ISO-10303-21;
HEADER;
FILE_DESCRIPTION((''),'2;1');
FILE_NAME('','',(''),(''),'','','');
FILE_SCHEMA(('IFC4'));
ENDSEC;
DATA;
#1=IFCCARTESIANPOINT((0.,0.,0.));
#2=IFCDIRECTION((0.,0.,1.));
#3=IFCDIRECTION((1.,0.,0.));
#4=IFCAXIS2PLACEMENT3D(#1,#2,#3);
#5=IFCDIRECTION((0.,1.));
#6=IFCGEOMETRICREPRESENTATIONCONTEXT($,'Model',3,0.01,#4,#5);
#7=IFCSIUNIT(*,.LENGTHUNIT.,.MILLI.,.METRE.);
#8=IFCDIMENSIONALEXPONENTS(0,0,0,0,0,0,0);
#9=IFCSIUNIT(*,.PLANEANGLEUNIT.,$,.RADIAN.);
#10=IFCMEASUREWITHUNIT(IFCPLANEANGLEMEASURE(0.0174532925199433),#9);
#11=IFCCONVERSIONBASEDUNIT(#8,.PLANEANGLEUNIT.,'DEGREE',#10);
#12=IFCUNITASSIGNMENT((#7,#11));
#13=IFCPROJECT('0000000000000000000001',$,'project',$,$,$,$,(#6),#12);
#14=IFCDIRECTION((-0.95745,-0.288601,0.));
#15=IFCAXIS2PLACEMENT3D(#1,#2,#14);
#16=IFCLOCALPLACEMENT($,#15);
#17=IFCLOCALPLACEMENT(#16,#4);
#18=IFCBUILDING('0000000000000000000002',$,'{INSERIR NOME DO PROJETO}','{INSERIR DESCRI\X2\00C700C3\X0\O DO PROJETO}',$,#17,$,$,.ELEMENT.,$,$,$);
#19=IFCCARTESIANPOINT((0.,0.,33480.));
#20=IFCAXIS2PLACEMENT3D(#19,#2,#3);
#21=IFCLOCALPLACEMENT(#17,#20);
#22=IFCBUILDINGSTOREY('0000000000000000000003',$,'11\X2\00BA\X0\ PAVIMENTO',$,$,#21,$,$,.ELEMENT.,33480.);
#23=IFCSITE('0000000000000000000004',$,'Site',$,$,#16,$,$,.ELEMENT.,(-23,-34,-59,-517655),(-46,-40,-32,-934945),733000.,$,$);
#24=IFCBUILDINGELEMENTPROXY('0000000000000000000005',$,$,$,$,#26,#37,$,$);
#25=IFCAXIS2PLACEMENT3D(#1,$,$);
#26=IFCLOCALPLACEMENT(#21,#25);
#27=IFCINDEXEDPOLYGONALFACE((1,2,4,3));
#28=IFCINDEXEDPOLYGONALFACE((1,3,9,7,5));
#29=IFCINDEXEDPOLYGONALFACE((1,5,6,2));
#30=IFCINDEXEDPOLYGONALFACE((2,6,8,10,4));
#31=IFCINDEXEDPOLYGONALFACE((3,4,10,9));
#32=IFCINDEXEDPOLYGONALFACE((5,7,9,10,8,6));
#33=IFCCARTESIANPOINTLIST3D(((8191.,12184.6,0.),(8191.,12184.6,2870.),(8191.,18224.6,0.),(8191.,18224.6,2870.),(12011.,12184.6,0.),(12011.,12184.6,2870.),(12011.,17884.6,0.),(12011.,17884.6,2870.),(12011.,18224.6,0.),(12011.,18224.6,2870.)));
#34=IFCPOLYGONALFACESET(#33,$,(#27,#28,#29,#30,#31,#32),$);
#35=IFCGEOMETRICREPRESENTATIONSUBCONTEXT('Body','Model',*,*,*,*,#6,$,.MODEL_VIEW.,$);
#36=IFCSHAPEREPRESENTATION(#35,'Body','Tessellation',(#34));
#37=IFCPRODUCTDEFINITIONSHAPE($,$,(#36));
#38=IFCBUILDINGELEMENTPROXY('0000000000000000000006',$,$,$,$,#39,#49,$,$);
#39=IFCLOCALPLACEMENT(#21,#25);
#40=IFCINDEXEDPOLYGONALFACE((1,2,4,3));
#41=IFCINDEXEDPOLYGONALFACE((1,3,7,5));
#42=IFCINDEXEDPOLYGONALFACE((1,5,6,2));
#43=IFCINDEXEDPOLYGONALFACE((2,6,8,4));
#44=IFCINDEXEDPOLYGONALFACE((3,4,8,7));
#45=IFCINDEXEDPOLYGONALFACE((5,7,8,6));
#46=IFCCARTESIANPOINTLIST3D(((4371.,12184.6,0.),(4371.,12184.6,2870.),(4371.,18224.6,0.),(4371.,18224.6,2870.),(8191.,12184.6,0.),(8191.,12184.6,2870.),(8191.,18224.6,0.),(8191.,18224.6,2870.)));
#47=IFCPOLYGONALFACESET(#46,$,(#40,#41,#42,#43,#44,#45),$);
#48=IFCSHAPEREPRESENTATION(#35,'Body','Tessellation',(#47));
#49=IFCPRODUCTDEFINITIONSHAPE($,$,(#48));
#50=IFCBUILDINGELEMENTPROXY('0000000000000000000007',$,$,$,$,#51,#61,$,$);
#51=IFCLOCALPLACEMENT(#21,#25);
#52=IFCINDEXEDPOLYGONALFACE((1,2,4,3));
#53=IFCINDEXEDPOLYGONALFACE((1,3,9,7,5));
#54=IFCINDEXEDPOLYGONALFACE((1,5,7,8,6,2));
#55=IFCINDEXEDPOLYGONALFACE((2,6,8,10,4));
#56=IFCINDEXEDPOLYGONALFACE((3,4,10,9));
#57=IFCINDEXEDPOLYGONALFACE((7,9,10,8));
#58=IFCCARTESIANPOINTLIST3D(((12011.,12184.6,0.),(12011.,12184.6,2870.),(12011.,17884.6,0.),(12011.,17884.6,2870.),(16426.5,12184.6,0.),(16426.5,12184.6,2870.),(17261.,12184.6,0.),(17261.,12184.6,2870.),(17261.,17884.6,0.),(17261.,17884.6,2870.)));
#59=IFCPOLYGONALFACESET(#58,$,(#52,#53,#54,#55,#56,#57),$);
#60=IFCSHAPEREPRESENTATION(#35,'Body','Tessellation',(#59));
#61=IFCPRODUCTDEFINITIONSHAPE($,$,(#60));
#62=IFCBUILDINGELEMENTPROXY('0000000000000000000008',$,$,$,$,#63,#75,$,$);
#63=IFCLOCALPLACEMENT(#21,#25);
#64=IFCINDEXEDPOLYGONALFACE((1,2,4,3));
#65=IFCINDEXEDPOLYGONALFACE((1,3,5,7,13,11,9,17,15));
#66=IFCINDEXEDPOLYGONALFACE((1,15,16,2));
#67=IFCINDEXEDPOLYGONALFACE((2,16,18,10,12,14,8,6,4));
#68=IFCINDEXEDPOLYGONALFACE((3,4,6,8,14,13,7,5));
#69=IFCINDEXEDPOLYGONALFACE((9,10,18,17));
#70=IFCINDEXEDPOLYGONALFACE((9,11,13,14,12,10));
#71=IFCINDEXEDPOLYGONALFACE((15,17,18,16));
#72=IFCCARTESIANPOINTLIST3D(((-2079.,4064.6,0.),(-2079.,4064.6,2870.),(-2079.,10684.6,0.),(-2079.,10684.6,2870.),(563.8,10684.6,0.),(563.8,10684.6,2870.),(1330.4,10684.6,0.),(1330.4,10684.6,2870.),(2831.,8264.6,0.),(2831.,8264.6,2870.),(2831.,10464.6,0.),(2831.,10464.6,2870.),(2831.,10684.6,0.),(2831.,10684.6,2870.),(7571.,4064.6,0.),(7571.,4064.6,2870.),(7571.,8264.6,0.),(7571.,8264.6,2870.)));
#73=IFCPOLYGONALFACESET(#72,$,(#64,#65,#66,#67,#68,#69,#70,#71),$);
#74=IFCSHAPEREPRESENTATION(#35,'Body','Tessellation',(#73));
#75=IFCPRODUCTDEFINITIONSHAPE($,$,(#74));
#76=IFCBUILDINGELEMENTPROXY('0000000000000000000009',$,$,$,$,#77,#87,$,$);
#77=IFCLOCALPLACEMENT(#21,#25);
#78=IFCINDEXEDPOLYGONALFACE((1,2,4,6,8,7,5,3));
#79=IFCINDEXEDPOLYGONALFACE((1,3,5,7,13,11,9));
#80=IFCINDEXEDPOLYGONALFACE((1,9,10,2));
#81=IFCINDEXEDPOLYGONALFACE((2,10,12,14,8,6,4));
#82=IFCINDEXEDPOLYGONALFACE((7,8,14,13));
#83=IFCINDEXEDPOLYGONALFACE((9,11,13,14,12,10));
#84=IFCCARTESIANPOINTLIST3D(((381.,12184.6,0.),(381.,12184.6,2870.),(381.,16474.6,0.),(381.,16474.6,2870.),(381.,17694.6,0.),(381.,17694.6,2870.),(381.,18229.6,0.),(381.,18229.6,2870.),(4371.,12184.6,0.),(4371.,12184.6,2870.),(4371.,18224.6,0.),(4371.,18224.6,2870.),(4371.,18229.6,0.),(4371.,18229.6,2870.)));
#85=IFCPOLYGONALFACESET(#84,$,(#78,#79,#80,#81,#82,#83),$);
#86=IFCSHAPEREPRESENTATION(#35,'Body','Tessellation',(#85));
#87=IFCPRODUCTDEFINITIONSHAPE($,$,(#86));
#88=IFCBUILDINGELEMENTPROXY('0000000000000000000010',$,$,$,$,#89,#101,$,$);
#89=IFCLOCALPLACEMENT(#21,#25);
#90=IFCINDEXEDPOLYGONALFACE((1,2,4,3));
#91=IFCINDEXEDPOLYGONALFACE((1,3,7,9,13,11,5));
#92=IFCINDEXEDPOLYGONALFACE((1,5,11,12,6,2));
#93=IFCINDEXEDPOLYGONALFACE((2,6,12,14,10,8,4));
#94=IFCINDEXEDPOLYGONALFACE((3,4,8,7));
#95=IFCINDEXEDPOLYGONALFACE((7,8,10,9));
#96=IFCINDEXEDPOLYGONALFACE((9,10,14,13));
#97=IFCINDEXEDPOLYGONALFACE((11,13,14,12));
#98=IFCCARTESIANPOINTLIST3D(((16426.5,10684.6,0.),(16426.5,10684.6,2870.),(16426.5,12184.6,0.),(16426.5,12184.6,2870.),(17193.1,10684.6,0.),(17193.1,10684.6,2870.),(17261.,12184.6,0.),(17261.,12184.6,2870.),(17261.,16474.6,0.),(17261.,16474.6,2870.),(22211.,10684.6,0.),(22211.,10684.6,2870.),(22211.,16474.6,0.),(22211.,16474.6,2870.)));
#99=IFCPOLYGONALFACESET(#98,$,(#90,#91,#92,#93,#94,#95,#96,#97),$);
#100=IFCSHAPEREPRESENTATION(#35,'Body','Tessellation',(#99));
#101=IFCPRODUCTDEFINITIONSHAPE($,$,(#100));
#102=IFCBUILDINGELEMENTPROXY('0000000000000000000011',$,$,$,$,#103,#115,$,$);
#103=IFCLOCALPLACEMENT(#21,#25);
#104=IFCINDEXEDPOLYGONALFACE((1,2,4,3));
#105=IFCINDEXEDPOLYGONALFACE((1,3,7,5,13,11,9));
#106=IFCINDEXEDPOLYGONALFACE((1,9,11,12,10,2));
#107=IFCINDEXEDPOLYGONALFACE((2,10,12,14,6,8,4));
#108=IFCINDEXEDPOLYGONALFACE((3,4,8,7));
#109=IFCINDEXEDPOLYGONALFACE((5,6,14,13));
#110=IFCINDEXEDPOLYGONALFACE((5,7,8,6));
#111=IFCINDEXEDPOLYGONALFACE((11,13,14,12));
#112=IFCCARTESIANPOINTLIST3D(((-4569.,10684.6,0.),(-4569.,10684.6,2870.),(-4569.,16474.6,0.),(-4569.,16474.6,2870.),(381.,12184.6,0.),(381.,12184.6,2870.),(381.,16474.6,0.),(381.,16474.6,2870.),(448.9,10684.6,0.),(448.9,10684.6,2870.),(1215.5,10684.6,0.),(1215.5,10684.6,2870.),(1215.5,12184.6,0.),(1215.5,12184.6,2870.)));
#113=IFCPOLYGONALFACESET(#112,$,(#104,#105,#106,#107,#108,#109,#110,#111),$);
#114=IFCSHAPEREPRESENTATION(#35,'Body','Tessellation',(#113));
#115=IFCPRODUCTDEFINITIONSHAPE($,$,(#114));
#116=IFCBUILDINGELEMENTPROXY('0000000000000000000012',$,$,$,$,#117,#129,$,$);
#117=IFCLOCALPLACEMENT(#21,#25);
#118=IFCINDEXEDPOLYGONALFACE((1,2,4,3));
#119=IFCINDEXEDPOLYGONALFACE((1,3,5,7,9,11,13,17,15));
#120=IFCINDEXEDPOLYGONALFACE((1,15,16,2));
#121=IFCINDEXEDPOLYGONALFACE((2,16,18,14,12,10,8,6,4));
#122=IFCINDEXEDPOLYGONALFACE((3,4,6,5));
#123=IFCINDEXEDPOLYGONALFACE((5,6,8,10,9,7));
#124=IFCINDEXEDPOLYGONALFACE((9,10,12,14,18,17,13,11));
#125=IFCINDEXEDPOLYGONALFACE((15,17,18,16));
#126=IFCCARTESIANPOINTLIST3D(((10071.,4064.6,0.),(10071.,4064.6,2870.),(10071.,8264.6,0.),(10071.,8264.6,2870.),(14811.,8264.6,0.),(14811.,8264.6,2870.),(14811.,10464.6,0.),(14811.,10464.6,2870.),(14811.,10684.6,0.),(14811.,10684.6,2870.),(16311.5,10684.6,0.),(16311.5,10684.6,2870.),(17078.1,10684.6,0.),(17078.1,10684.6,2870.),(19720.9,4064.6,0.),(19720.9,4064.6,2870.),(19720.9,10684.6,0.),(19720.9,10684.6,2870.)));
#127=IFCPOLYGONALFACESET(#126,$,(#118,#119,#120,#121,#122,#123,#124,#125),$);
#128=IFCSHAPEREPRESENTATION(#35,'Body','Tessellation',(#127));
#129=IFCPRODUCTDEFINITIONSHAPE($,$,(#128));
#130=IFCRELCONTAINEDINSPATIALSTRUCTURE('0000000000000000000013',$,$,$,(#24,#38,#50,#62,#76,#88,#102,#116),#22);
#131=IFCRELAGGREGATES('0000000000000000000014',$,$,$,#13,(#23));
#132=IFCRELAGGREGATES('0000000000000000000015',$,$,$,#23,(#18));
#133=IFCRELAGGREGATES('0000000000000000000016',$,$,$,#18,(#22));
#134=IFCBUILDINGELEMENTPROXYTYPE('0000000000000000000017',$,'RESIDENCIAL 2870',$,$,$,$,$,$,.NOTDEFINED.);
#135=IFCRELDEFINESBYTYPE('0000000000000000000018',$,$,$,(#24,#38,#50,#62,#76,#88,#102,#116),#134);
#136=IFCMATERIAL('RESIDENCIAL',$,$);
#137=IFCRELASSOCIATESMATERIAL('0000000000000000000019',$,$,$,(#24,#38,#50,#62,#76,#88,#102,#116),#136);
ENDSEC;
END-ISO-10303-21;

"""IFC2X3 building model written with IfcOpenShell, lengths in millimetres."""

from ifc_helpers import new_model, entity, si_unit, converted_unit, direction, frame, origin_with_axes, place, context, subcontext, project, spatial, polyline, outline, extrude, material, type_object, element, save


model = new_model("IFC2X3")

# Units and contexts
model_context = context("Model", 3, precision=0.01, world=origin_with_axes(), true_north=direction((0.0, 1.0)))
body_context = subcontext(model_context, "Body", "Model", "MODEL_VIEW")
ifc_project = project(units=[si_unit("LENGTHUNIT", "METRE", prefix="MILLI"), converted_unit("PLANEANGLEUNIT", "DEGREE", entity("IfcPlaneAngleMeasure", 0.0174532925199433), si_unit("PLANEANGLEUNIT", "RADIAN"), dimensions=[0, 0, 0, 0, 0, 0, 0])], contexts=[model_context])

# Site, building, storey
site_placement = place(None, frame((0.0, 0.0, 0.0), z_axis=(0.0, 0.0, 1.0), x_axis=(-0.95745, -0.288601, 0.0)))
site = spatial("IfcSite", under=ifc_project, at=site_placement, Name="Site", CompositionType="ELEMENT", RefLatitude=(-23, -34, -59, -517655), RefLongitude=(-46, -40, -32, -934945), RefElevation=733000.0)
building_placement = place(site_placement, origin_with_axes())
building = spatial("IfcBuilding", under=site, at=building_placement, Name="{INSERIR NOME DO PROJETO}", Description="{INSERIR DESCRIÇÃO DO PROJETO}", CompositionType="ELEMENT")
storey_placement = place(building_placement, frame((0.0, 0.0, 33480.0), z_axis=(0.0, 0.0, 1.0), x_axis=(1.0, 0.0, 0.0)))
storey = spatial("IfcBuildingStorey", under=building, at=storey_placement, Name="11º PAVIMENTO", CompositionType="ELEMENT", Elevation=33480.0)

# Building element proxies
ifc_material_1 = material(Name="RESIDENCIAL")
building_element_proxy_type_1 = type_object("IfcBuildingElementProxyType", Name="RESIDENCIAL 2870", PredefinedType="NOTDEFINED")
proxy_1_placement = place(storey_placement, frame((8191.0, 18224.6, 0.0), z_axis=(0.0, 0.0, 1.0), x_axis=(1.0, 0.0, 0.0)))
element("IfcBuildingElementProxy", 1, at=proxy_1_placement, inside=storey, type_object=building_element_proxy_type_1, material=ifc_material_1, context=body_context, shape_type="SweptSolid", body=[
    extrude(outline(polyline([(0.0, 0.0), (0.0, -6040.0), (3820.0, -6040.0), (3820.0, -340.0), (3820.0, 0.0), (0.0, 0.0)])), origin_with_axes(), (0.0, 0.0, 1.0), 2870.0),
])
proxy_2_placement = place(storey_placement, frame((4371.0, 18224.6, 0.0), z_axis=(0.0, 0.0, 1.0), x_axis=(1.0, 0.0, 0.0)))
element("IfcBuildingElementProxy", 2, at=proxy_2_placement, inside=storey, type_object=building_element_proxy_type_1, material=ifc_material_1, context=body_context, shape_type="SweptSolid", body=[
    extrude(outline(polyline([(0.0, 0.0), (0.0, -6040.0), (3820.0, -6040.0), (3820.0, 0.0), (0.0, 0.0)])), origin_with_axes(), (0.0, 0.0, 1.0), 2870.0),
])
proxy_3_placement = place(storey_placement, frame((12011.0, 12184.6, 0.0), z_axis=(0.0, 0.0, 1.0), x_axis=(1.0, 0.0, 0.0)))
element("IfcBuildingElementProxy", 3, at=proxy_3_placement, inside=storey, type_object=building_element_proxy_type_1, material=ifc_material_1, context=body_context, shape_type="SweptSolid", body=[
    extrude(outline(polyline([(0.0, 0.0), (4415.5, 0.0), (5250.0, 0.0), (5250.0, 5700.0), (0.0, 5700.0), (0.0, 0.0)])), origin_with_axes(), (0.0, 0.0, 1.0), 2870.0),
])
proxy_4_placement = place(storey_placement, frame((-2079.0, 4064.6, 0.0), z_axis=(0.0, 0.0, 1.0), x_axis=(1.0, 0.0, 0.0)))
element("IfcBuildingElementProxy", 4, at=proxy_4_placement, inside=storey, type_object=building_element_proxy_type_1, material=ifc_material_1, context=body_context, shape_type="SweptSolid", body=[
    extrude(outline(polyline([(0.0, 0.0), (9650.0, 0.0), (9650.0, 4200.0), (4910.0, 4200.0), (4910.0, 6400.0), (4910.0, 6620.0), (3409.4, 6620.0), (2642.8, 6620.0), (0.0, 6620.0), (0.0, 0.0)])), origin_with_axes(), (0.0, 0.0, 1.0), 2870.0),
])
proxy_5_placement = place(storey_placement, frame((381.0, 16474.6, 0.0), z_axis=(0.0, 0.0, 1.0), x_axis=(1.0, 0.0, 0.0)))
element("IfcBuildingElementProxy", 5, at=proxy_5_placement, inside=storey, type_object=building_element_proxy_type_1, material=ifc_material_1, context=body_context, shape_type="SweptSolid", body=[
    extrude(outline(polyline([(0.0, 0.0), (0.0, -4290.0), (3990.0, -4290.0), (3990.0, 1750.0), (3990.0, 1755.0), (0.0, 1755.0), (0.0, 1220.0), (0.0, 0.0)])), origin_with_axes(), (0.0, 0.0, 1.0), 2870.0),
])
proxy_6_placement = place(storey_placement, frame((17261.0, 12184.6, 0.0), z_axis=(0.0, 0.0, 1.0), x_axis=(1.0, 0.0, 0.0)))
element("IfcBuildingElementProxy", 6, at=proxy_6_placement, inside=storey, type_object=building_element_proxy_type_1, material=ifc_material_1, context=body_context, shape_type="SweptSolid", body=[
    extrude(outline(polyline([(0.0, 0.0), (-834.5, 0.0), (-834.5, -1500.0), (-67.9, -1500.0), (4950.0, -1500.0), (4950.0, 4290.0), (0.0, 4290.0), (0.0, 0.0)])), origin_with_axes(), (0.0, 0.0, 1.0), 2870.0),
])
proxy_7_placement = place(storey_placement, frame((-4569.0, 16474.6, 0.0), z_axis=(0.0, 0.0, 1.0), x_axis=(1.0, 0.0, 0.0)))
element("IfcBuildingElementProxy", 7, at=proxy_7_placement, inside=storey, type_object=building_element_proxy_type_1, material=ifc_material_1, context=body_context, shape_type="SweptSolid", body=[
    extrude(outline(polyline([(0.0, 0.0), (0.0, -5790.0), (5017.9, -5790.0), (5784.5, -5790.0), (5784.5, -4290.0), (4950.0, -4290.0), (4950.0, 0.0), (0.0, 0.0)])), origin_with_axes(), (0.0, 0.0, 1.0), 2870.0),
])
proxy_8_placement = place(storey_placement, frame((19720.9, 4064.6, 0.0), z_axis=(0.0, 0.0, 1.0), x_axis=(1.0, 0.0, 0.0)))
element("IfcBuildingElementProxy", 8, at=proxy_8_placement, inside=storey, type_object=building_element_proxy_type_1, material=ifc_material_1, context=body_context, shape_type="SweptSolid", body=[
    extrude(outline(polyline([(0.0, 0.0), (0.0, 6620.0), (-2642.8, 6620.0), (-3409.4, 6620.0), (-4910.0, 6620.0), (-4910.0, 6400.0), (-4910.0, 4200.0), (-9650.0, 4200.0), (-9650.0, 0.0), (0.0, 0.0)])), origin_with_axes(), (0.0, 0.0, 1.0), 2870.0),
])

save(model, "model.ifc")
